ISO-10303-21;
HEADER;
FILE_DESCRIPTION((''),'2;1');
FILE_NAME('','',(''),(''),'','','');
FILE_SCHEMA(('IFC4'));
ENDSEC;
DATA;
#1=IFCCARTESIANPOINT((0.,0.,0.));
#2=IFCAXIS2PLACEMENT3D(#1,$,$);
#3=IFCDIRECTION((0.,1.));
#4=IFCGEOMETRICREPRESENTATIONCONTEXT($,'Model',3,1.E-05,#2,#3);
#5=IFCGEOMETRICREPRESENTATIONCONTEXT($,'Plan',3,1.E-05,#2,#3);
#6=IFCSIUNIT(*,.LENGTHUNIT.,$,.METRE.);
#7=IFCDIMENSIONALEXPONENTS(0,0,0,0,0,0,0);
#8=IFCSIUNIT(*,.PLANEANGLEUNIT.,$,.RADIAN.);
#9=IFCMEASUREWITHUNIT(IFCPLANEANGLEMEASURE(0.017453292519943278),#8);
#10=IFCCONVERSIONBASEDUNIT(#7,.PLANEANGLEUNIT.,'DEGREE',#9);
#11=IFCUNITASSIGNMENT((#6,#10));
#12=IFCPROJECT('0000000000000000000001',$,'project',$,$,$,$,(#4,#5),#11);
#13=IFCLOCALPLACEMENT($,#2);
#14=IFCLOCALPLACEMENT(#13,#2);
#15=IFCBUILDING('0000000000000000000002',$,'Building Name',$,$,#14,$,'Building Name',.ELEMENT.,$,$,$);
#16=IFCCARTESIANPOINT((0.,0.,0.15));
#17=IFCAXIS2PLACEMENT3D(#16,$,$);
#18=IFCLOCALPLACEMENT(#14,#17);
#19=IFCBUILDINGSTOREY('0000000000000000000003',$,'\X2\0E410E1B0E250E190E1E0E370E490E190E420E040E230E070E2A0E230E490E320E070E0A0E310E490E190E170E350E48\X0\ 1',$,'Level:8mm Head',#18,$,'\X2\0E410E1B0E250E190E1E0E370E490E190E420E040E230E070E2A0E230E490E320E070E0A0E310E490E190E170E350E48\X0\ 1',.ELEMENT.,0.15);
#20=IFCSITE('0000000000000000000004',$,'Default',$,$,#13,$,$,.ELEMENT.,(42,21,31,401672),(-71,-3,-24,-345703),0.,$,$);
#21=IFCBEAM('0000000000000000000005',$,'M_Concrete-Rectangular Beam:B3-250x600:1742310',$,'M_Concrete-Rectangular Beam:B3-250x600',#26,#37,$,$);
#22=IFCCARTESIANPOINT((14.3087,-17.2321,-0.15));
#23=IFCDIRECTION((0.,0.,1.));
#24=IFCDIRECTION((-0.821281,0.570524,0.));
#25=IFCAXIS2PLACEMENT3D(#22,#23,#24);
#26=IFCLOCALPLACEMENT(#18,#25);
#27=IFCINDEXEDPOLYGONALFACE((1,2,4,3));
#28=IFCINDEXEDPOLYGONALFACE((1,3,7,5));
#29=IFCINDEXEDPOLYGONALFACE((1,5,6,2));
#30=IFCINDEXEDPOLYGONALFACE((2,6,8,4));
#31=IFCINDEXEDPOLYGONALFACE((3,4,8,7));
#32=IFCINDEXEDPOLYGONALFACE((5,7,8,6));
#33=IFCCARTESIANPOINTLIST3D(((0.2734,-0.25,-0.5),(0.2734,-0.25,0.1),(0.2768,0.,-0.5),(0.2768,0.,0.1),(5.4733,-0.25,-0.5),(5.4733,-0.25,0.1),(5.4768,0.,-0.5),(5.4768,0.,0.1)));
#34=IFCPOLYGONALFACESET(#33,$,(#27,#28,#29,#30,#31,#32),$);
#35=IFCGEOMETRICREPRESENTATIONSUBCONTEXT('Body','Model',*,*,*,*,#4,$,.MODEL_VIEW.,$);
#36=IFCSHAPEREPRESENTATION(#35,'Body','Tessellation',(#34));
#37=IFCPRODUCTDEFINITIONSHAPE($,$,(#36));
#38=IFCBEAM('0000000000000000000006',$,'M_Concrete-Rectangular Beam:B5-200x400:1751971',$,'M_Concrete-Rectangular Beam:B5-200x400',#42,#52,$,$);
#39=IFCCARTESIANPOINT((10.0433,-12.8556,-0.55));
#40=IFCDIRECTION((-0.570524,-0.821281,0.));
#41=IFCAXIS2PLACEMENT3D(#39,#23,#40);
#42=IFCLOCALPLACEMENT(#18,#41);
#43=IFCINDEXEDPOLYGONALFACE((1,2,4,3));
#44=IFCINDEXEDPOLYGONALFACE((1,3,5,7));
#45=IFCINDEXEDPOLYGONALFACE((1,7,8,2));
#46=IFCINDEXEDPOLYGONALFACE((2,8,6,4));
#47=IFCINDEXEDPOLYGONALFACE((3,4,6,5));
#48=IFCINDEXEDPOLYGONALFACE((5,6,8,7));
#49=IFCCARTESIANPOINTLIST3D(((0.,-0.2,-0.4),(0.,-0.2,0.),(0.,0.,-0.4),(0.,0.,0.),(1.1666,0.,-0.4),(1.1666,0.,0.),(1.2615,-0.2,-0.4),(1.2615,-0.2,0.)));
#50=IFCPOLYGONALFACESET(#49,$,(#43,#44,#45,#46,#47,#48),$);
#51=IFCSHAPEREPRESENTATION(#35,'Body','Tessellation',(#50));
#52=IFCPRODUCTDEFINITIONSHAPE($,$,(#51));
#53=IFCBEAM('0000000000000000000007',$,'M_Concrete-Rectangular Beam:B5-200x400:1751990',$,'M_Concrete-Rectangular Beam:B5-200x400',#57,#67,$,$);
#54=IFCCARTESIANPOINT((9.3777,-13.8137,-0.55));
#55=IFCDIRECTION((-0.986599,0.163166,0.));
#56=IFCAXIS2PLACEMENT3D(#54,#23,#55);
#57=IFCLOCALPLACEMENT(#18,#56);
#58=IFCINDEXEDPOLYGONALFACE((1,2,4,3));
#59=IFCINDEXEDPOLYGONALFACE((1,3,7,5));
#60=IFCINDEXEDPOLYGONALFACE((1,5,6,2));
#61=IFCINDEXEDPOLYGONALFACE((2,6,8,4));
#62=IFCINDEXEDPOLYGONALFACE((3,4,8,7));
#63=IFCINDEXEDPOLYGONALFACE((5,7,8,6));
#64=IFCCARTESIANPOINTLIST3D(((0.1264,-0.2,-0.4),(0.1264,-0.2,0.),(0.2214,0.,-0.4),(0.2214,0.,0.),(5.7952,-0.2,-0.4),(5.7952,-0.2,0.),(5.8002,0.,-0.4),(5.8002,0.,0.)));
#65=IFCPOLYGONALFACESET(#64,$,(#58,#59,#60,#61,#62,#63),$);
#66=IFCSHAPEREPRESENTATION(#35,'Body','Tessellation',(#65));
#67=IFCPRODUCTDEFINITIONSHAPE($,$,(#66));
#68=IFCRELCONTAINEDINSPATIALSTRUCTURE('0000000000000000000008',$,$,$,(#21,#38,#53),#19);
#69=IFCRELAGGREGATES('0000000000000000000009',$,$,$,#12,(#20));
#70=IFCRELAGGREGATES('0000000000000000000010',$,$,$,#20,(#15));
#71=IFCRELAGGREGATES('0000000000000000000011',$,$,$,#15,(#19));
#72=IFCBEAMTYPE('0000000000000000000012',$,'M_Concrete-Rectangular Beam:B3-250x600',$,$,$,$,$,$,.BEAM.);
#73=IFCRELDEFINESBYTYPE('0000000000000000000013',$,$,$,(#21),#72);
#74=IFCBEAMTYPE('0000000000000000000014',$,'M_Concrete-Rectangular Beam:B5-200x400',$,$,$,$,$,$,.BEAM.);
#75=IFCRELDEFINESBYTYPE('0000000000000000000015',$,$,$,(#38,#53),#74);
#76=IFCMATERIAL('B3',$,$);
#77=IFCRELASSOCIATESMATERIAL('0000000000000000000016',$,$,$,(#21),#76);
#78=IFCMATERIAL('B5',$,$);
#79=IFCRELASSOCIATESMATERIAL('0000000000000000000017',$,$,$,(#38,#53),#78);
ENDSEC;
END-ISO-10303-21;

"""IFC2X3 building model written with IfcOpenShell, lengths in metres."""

from ifc_helpers import new_model, entity, si_unit, converted_unit, direction, frame, frame_2d, origin, place, context, subcontext, project, spatial, rectangle, extrude, clip, halfspace, material, type_object, element, save


model = new_model("IFC2X3")

# Units and contexts
model_context = context("Model", 3, precision=1e-05, world=origin(), true_north=direction((0.0, 1.0)))
plan_context = context("Plan", 3, precision=1e-05, world=origin(), true_north=direction((0.0, 1.0)))
body_context = subcontext(model_context, "Body", "Model", "MODEL_VIEW")
ifc_project = project(units=[si_unit("LENGTHUNIT", "METRE"), converted_unit("PLANEANGLEUNIT", "DEGREE", entity("IfcPlaneAngleMeasure", 0.017453292519943278), si_unit("PLANEANGLEUNIT", "RADIAN"), dimensions=[0, 0, 0, 0, 0, 0, 0])], contexts=[model_context, plan_context])

# Site, building, storey
site_placement = place(None, origin())
site = spatial("IfcSite", under=ifc_project, at=site_placement, Name="Default", CompositionType="ELEMENT", RefLatitude=(42, 21, 31, 401672), RefLongitude=(-71, -3, -24, -345703), RefElevation=0.0)
building_placement = place(site_placement, origin())
building = spatial("IfcBuilding", under=site, at=building_placement, Name="Building Name", LongName="Building Name", CompositionType="ELEMENT")
storey_placement = place(building_placement, frame((0.0, 0.0, 0.15)))
storey = spatial("IfcBuildingStorey", under=building, at=storey_placement, Name="แปลนพื้นโครงสร้างชั้นที่ 1", ObjectType="Level:8mm Head", LongName="แปลนพื้นโครงสร้างชั้นที่ 1", CompositionType="ELEMENT", Elevation=0.15)

# Beams
ifc_material_1 = material(Name="B3")
beam_type_1 = type_object("IfcBeamType", Name="M_Concrete-Rectangular Beam:B3-250x600", PredefinedType="BEAM")
beam_1_placement = place(storey_placement, frame((14.3087, -17.2321, -0.15), z_axis=(0.0, 0.0, 1.0), x_axis=(-0.821281, 0.570524, 0.0)))
element("IfcBeam", 1, at=beam_1_placement, inside=storey, type_object=beam_type_1, material=ifc_material_1, Name="M_Concrete-Rectangular Beam:B3-250x600:1742310", ObjectType="M_Concrete-Rectangular Beam:B3-250x600", context=body_context, shape_type="Clipping", body=[
    clip(clip(extrude(rectangle(XDim=0.6, YDim=0.25, at=frame_2d((0.0, 0.0), x_axis=(1.0, 0.0))), frame((0.2734, -0.125, -0.2), z_axis=(1.0, 0.0, 0.0), x_axis=(0.0, 0.0, -1.0)), (0.0, 0.0, 1.0), 5.2034), halfspace(frame((5.4772, 0.0271, 0.1), z_axis=(0.999904, -0.013876, 0.0), x_axis=(0.0, 0.0, -1.0)), False)), halfspace(frame((0.273, -0.2771, 0.1), z_axis=(-0.999904, 0.013876, 0.0), x_axis=(0.0, 0.0, -1.0)), False)),
])
ifc_material_2 = material(Name="B5")
beam_type_2 = type_object("IfcBeamType", Name="M_Concrete-Rectangular Beam:B5-200x400", PredefinedType="BEAM")
beam_2_placement = place(storey_placement, frame((10.0433, -12.8556, -0.55), z_axis=(0.0, 0.0, 1.0), x_axis=(-0.570524, -0.821281, 0.0)))
element("IfcBeam", 2, at=beam_2_placement, inside=storey, type_object=beam_type_2, material=ifc_material_2, Name="M_Concrete-Rectangular Beam:B5-200x400:1751971", ObjectType="M_Concrete-Rectangular Beam:B5-200x400", context=body_context, shape_type="Clipping", body=[
    clip(extrude(rectangle(XDim=0.4, YDim=0.2, at=frame_2d((0.0, 0.0), x_axis=(1.0, 0.0))), frame((0.0, -0.1, -0.2), z_axis=(1.0, 0.0, 0.0), x_axis=(0.0, 0.0, -1.0)), (0.0, 0.0, 1.0), 1.2615), halfspace(frame((1.1357, 0.0651, 0.0), z_axis=(0.903365, 0.428872, 0.0), x_axis=(0.428872, -0.903365, 0.0)), False)),
])
beam_3_placement = place(storey_placement, frame((9.3777, -13.8137, -0.55), z_axis=(0.0, 0.0, 1.0), x_axis=(-0.986599, 0.163166, 0.0)))
element("IfcBeam", 3, at=beam_3_placement, inside=storey, type_object=beam_type_2, material=ifc_material_2, Name="M_Concrete-Rectangular Beam:B5-200x400:1751990", ObjectType="M_Concrete-Rectangular Beam:B5-200x400", context=body_context, shape_type="Clipping", body=[
    clip(clip(extrude(rectangle(XDim=0.4, YDim=0.2, at=frame_2d((0.0, 0.0), x_axis=(1.0, 0.0))), frame((0.1264, -0.1, -0.2), z_axis=(1.0, 0.0, 0.0), x_axis=(0.0, 0.0, -1.0)), (0.0, 0.0, 1.0), 5.6738), halfspace(frame((5.7952, -0.2, 0.0), z_axis=(0.999688, -0.024982, 0.0), x_axis=(-0.024982, -0.999688, 0.0)), False)), halfspace(frame((0.0977, -0.2605, 0.0), z_axis=(-0.903365, 0.428872, 0.0), x_axis=(-0.428872, -0.903365, 0.0)), False)),
])

save(model, "model.ifc")
